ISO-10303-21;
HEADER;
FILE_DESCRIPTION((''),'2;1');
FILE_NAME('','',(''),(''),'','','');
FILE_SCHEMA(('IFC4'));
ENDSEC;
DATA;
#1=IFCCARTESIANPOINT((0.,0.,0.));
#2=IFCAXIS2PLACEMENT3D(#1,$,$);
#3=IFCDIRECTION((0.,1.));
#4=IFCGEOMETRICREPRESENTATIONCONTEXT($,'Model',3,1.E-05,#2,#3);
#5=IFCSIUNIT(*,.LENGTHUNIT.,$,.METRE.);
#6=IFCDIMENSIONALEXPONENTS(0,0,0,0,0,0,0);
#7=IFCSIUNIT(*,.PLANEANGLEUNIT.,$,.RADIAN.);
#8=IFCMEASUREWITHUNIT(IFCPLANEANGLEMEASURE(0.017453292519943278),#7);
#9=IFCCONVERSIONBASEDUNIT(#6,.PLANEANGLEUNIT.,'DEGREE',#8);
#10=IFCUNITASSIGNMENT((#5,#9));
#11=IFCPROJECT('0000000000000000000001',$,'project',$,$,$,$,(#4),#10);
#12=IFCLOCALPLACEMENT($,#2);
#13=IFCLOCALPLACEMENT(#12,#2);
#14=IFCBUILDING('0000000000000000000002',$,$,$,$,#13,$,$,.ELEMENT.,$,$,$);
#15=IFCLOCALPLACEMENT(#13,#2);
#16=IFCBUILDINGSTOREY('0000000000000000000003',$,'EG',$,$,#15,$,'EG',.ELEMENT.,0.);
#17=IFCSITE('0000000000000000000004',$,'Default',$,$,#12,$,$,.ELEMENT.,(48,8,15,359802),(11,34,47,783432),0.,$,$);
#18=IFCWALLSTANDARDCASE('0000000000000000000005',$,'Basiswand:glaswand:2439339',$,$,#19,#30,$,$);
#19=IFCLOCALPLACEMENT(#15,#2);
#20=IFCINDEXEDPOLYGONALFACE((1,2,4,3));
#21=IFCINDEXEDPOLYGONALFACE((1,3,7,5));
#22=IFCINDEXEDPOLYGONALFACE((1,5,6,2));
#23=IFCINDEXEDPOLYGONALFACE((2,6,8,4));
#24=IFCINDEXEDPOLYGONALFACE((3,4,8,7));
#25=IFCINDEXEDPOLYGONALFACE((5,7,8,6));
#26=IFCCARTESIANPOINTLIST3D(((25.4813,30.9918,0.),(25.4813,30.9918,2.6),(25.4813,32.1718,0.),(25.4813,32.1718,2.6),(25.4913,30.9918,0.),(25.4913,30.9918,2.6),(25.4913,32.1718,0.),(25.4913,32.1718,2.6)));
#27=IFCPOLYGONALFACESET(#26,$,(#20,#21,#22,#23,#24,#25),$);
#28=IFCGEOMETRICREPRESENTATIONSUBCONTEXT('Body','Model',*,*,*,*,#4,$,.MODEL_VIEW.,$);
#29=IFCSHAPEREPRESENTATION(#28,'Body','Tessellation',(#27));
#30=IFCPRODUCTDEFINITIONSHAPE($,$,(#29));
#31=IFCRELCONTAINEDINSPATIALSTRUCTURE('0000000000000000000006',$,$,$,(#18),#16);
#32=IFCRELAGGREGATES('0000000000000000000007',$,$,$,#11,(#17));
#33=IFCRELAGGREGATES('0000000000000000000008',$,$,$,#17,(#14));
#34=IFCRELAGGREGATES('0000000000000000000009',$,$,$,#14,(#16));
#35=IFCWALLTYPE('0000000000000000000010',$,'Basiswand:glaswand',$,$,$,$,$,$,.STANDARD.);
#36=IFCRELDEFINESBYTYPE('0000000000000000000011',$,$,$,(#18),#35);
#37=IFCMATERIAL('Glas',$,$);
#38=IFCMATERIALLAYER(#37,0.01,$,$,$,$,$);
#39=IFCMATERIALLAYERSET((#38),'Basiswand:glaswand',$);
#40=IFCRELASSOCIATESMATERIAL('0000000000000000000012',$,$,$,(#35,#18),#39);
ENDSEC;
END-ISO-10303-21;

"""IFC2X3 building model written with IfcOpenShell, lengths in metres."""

from ifc_helpers import new_model, entity, si_unit, converted_unit, direction, frame, frame_2d, origin, place, context, subcontext, project, spatial, rectangle, extrude, material, layer, layer_set, layer_usage, type_object, element, save


model = new_model("IFC2X3")

# Units and contexts
model_context = context("Model", 3, precision=1e-05, world=origin(), true_north=direction((0.0, 1.0)))
body_context = subcontext(model_context, "Body", "Model", "MODEL_VIEW")
ifc_project = project(units=[si_unit("LENGTHUNIT", "METRE"), converted_unit("PLANEANGLEUNIT", "DEGREE", entity("IfcPlaneAngleMeasure", 0.017453292519943278), si_unit("PLANEANGLEUNIT", "RADIAN"), dimensions=[0, 0, 0, 0, 0, 0, 0])], contexts=[model_context])

# Site, building, storey
site_placement = place(None, origin())
site = spatial("IfcSite", under=ifc_project, at=site_placement, Name="Default", CompositionType="ELEMENT", RefLatitude=(48, 8, 15, 359802), RefLongitude=(11, 34, 47, 783432), RefElevation=0.0)
building_placement = place(site_placement, origin())
building = spatial("IfcBuilding", under=site, at=building_placement, CompositionType="ELEMENT")
storey_placement = place(building_placement, origin())
storey = spatial("IfcBuildingStorey", under=building, at=storey_placement, Name="EG", LongName="EG", CompositionType="ELEMENT", Elevation=0.0)

# Wall
ifc_material_1 = material(Name="Glas")
ifc_layer_1 = layer(ifc_material_1, 0.01)
ifc_layer_set_1 = layer_set([ifc_layer_1], Name="Basiswand:glaswand")
ifc_layer_usage_1 = layer_usage(ifc_layer_set_1, "AXIS2", "NEGATIVE", 0.005)
wall_type_1 = type_object("IfcWallType", Name="Basiswand:glaswand", PredefinedType="STANDARD", material=ifc_layer_set_1)
wall_1_placement = place(storey_placement, frame((25.4863, 32.1718, 0.0), z_axis=(0.0, 0.0, 1.0), x_axis=(0.0, -1.0, 0.0)))
element("IfcWallStandardCase", 1, at=wall_1_placement, inside=storey, type_object=wall_type_1, material=ifc_layer_usage_1, Name="Basiswand:glaswand:2439339", context=body_context, shape_type="SweptSolid", body=[
    extrude(rectangle(XDim=1.18, YDim=0.01, at=frame_2d((0.59, 0.0), x_axis=(-1.0, 0.0))), origin(), (0.0, 0.0, 1.0), 2.6),
])

save(model, "model.ifc")
